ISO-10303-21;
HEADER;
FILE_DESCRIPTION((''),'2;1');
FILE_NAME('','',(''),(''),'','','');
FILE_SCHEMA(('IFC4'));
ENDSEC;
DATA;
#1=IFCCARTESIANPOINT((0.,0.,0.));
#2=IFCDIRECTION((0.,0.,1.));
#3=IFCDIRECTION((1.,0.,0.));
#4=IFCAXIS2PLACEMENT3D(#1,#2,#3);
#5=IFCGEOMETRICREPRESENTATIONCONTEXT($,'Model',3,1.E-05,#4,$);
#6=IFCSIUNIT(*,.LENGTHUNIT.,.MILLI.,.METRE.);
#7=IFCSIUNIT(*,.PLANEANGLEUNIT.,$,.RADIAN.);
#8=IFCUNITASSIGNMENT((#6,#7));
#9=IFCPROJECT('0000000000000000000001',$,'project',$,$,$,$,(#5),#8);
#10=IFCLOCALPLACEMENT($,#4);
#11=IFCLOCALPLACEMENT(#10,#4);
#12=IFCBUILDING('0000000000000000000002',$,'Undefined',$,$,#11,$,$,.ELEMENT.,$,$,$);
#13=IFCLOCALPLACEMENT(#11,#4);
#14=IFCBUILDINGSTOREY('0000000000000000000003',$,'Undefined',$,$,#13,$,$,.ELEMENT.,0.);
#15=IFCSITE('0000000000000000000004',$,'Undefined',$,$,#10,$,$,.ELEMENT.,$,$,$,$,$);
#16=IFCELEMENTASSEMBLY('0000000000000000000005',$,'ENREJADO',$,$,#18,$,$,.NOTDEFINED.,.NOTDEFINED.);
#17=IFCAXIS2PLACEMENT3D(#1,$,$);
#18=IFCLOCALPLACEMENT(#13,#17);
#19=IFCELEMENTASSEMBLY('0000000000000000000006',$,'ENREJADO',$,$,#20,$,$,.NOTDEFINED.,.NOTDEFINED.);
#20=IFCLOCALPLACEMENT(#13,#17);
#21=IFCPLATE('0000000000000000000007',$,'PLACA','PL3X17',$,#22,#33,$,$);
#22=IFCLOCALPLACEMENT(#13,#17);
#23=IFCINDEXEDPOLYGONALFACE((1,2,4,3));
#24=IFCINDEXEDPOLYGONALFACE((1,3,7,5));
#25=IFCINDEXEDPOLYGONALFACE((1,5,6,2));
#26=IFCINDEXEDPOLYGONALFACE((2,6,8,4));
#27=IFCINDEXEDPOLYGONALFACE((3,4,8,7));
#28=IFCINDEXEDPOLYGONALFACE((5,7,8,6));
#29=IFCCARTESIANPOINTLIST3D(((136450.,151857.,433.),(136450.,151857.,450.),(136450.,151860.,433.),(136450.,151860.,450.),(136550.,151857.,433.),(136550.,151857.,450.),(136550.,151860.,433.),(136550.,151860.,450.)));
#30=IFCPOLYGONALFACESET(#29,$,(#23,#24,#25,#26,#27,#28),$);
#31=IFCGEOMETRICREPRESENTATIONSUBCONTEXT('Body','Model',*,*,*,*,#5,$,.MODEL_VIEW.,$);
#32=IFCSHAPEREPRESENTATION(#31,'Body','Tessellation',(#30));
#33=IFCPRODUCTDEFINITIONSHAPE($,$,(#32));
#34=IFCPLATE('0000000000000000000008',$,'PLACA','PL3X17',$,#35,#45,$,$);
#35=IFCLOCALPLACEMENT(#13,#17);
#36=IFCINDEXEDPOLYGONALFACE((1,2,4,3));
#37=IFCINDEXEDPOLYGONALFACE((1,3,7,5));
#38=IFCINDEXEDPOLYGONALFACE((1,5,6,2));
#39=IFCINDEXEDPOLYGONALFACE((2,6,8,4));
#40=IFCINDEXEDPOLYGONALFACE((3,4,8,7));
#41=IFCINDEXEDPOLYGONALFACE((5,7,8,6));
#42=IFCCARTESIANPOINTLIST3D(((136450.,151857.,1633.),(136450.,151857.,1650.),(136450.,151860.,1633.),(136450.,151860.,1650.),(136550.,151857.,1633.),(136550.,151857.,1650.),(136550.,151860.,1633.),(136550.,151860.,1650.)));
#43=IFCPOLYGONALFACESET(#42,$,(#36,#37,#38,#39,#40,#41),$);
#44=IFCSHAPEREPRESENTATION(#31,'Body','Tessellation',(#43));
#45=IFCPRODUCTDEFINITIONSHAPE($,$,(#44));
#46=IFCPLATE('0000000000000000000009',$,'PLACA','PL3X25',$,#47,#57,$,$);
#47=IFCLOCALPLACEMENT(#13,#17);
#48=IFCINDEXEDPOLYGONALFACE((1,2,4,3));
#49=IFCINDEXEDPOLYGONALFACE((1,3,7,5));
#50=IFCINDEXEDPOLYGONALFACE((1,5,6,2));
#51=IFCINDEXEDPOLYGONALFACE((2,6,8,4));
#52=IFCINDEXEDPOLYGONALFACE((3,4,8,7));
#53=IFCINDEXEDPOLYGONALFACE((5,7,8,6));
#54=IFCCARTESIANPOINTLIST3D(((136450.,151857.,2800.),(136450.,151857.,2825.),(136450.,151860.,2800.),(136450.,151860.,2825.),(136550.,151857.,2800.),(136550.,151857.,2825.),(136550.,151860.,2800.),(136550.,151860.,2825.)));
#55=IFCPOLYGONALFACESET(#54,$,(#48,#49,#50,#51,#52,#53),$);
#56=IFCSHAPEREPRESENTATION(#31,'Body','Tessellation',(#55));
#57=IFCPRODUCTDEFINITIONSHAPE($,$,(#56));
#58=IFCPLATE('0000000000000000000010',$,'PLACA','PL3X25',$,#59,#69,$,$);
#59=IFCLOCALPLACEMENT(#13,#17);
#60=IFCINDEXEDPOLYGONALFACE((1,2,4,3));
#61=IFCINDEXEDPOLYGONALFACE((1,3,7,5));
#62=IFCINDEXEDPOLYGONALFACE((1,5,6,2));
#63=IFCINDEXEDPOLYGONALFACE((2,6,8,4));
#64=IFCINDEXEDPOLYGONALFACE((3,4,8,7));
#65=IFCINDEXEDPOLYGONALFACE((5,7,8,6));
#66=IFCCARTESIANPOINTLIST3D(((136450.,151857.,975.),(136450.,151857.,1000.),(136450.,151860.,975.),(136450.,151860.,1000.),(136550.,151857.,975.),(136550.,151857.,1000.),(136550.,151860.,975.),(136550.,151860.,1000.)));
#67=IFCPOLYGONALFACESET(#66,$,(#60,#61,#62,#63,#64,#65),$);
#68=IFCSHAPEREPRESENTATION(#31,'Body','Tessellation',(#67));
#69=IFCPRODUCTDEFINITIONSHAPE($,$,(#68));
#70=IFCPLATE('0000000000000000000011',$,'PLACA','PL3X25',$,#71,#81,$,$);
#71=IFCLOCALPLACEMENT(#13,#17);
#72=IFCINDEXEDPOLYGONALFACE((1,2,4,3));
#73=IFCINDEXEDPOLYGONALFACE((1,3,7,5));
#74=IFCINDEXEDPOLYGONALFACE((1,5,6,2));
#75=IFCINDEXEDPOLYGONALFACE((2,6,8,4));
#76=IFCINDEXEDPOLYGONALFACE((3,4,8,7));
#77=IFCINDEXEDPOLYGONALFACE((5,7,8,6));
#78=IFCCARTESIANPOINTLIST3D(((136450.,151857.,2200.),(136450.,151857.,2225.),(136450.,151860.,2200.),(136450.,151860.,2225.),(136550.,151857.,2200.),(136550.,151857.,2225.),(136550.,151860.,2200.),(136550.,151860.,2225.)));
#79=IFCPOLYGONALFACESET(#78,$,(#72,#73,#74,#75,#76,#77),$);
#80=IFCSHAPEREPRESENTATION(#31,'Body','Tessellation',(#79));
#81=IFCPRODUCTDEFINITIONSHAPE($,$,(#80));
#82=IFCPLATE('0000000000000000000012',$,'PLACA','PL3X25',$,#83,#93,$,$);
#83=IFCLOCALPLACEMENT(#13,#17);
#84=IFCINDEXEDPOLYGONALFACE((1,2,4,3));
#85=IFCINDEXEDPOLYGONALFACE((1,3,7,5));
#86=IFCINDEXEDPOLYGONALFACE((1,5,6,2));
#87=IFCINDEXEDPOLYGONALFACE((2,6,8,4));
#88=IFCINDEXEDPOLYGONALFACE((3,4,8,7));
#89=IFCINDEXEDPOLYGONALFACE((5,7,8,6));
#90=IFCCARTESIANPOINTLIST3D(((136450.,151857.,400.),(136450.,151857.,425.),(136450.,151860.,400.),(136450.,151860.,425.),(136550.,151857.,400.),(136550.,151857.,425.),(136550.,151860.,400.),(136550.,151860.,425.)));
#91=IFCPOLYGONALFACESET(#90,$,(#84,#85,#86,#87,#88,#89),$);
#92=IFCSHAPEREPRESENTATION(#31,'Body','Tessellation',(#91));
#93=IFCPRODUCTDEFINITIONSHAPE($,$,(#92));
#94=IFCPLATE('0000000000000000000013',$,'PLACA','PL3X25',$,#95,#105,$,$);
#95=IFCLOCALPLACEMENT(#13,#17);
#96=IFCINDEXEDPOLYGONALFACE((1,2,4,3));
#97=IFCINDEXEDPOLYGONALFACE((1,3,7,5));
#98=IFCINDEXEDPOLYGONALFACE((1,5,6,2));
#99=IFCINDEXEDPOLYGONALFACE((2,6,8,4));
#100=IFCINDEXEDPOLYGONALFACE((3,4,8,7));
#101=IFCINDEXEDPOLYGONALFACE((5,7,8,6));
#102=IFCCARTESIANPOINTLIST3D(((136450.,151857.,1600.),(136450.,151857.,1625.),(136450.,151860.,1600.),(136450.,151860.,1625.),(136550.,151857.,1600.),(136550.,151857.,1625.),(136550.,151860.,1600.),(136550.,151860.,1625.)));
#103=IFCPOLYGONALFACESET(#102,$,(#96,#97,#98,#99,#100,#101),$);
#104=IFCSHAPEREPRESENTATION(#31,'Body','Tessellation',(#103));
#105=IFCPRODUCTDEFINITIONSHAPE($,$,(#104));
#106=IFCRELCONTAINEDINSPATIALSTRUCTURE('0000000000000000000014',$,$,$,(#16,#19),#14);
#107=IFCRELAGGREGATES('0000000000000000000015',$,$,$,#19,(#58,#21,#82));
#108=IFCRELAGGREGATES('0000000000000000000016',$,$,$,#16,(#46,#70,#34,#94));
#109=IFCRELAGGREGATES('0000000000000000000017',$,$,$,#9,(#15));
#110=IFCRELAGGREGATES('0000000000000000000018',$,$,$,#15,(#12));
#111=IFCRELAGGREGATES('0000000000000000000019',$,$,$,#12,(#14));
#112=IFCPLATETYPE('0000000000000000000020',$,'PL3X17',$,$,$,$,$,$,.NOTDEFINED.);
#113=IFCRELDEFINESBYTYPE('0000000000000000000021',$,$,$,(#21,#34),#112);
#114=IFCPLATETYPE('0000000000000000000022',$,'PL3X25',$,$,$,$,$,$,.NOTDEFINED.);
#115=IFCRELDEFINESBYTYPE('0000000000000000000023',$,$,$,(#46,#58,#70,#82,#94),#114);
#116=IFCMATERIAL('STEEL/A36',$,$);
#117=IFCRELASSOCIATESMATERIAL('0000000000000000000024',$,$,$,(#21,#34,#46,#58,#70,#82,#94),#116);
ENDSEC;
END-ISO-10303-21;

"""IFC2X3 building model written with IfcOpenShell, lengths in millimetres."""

from ifc_helpers import new_model, si_unit, frame, origin_with_axes, place, context, subcontext, project, spatial, polyline, outline, extrude, material, type_object, element, aggregate, save


model = new_model("IFC2X3")

# Units and contexts
model_context = context("Model", 3, precision=1e-05, world=origin_with_axes())
body_context = subcontext(model_context, "Body", "Model", "MODEL_VIEW")
ifc_project = project(units=[si_unit("LENGTHUNIT", "METRE", prefix="MILLI"), si_unit("PLANEANGLEUNIT", "RADIAN")], contexts=[model_context])

# Site, building, storey
site_placement = place(None, origin_with_axes())
site = spatial("IfcSite", under=ifc_project, at=site_placement, Name="Undefined", CompositionType="ELEMENT")
building_placement = place(site_placement, origin_with_axes())
building = spatial("IfcBuilding", under=site, at=building_placement, Name="Undefined", CompositionType="ELEMENT")
storey_placement = place(building_placement, origin_with_axes())
storey = spatial("IfcBuildingStorey", under=building, at=storey_placement, Name="Undefined", CompositionType="ELEMENT", Elevation=0.0)

# Shared definitions
ifc_material_1 = material(Name="STEEL/A36")

# Element assemblies
assembly_1_placement = place(storey_placement, origin_with_axes())
assembly_1 = element("IfcElementAssembly", 1, at=assembly_1_placement, inside=storey, Name="ENREJADO", AssemblyPlace="NOTDEFINED", PredefinedType="NOTDEFINED")
assembly_2_placement = place(storey_placement, origin_with_axes())
assembly_2 = element("IfcElementAssembly", 2, at=assembly_2_placement, inside=storey, Name="ENREJADO", AssemblyPlace="NOTDEFINED", PredefinedType="NOTDEFINED")

# Plates
plate_type_1 = type_object("IfcPlateType", Name="PL3X17", PredefinedType="NOTDEFINED")
plate_1_placement = place(assembly_2_placement, frame((136450.0, 151858.5, 450.0), z_axis=(0.0, -1.0, 0.0), x_axis=(0.0, 0.0, -1.0)))
plate_1 = element("IfcPlate", 3, at=plate_1_placement, type_object=plate_type_1, material=ifc_material_1, Name="PLACA", Description="PL3X17", context=body_context, shape_type="SweptSolid", body=[
    extrude(outline(polyline([(0.0, 0.0), (17.0, 0.0), (17.0, 100.0), (0.0, 100.0), (0.0, 0.0)])), frame((0.0, 0.0, -1.5), z_axis=(0.0, 0.0, 1.0), x_axis=(1.0, 0.0, 0.0)), (0.0, 0.0, 1.0), 3.0),
])
plate_2_placement = place(assembly_1_placement, frame((136450.0, 151858.5, 1650.0), z_axis=(0.0, -1.0, 0.0), x_axis=(0.0, 0.0, -1.0)))
plate_2 = element("IfcPlate", 4, at=plate_2_placement, type_object=plate_type_1, material=ifc_material_1, Name="PLACA", Description="PL3X17", context=body_context, shape_type="SweptSolid", body=[
    extrude(outline(polyline([(0.0, 0.0), (17.0, 0.0), (17.0, 100.0), (0.0, 100.0), (0.0, 0.0)])), frame((0.0, 0.0, -1.5), z_axis=(0.0, 0.0, 1.0), x_axis=(1.0, 0.0, 0.0)), (0.0, 0.0, 1.0), 3.0),
])
plate_type_2 = type_object("IfcPlateType", Name="PL3X25", PredefinedType="NOTDEFINED")
plate_3_placement = place(assembly_1_placement, frame((136450.0, 151858.5, 2825.0), z_axis=(0.0, -1.0, 0.0), x_axis=(0.0, 0.0, -1.0)))
plate_3 = element("IfcPlate", 5, at=plate_3_placement, type_object=plate_type_2, material=ifc_material_1, Name="PLACA", Description="PL3X25", context=body_context, shape_type="SweptSolid", body=[
    extrude(outline(polyline([(0.0, 0.0), (25.0, 0.0), (25.0, 100.0), (0.0, 100.0), (0.0, 0.0)])), frame((0.0, 0.0, -1.5), z_axis=(0.0, 0.0, 1.0), x_axis=(1.0, 0.0, 0.0)), (0.0, 0.0, 1.0), 3.0),
])
plate_4_placement = place(assembly_2_placement, frame((136450.0, 151858.5, 1000.0), z_axis=(0.0, -1.0, 0.0), x_axis=(0.0, 0.0, -1.0)))
plate_4 = element("IfcPlate", 6, at=plate_4_placement, type_object=plate_type_2, material=ifc_material_1, Name="PLACA", Description="PL3X25", context=body_context, shape_type="SweptSolid", body=[
    extrude(outline(polyline([(0.0, 0.0), (25.0, 0.0), (25.0, 100.0), (0.0, 100.0), (0.0, 0.0)])), frame((0.0, 0.0, -1.5), z_axis=(0.0, 0.0, 1.0), x_axis=(1.0, 0.0, 0.0)), (0.0, 0.0, 1.0), 3.0),
])
plate_5_placement = place(assembly_1_placement, frame((136450.0, 151858.5, 2225.0), z_axis=(0.0, -1.0, 0.0), x_axis=(0.0, 0.0, -1.0)))
plate_5 = element("IfcPlate", 7, at=plate_5_placement, type_object=plate_type_2, material=ifc_material_1, Name="PLACA", Description="PL3X25", context=body_context, shape_type="SweptSolid", body=[
    extrude(outline(polyline([(0.0, 0.0), (25.0, 0.0), (25.0, 100.0), (0.0, 100.0), (0.0, 0.0)])), frame((0.0, 0.0, -1.5), z_axis=(0.0, 0.0, 1.0), x_axis=(1.0, 0.0, 0.0)), (0.0, 0.0, 1.0), 3.0),
])
plate_6_placement = place(assembly_2_placement, frame((136450.0, 151858.5, 425.0), z_axis=(0.0, -1.0, 0.0), x_axis=(0.0, 0.0, -1.0)))
plate_6 = element("IfcPlate", 8, at=plate_6_placement, type_object=plate_type_2, material=ifc_material_1, Name="PLACA", Description="PL3X25", context=body_context, shape_type="SweptSolid", body=[
    extrude(outline(polyline([(0.0, 0.0), (25.0, 0.0), (25.0, 100.0), (0.0, 100.0), (0.0, 0.0)])), frame((0.0, 0.0, -1.5), z_axis=(0.0, 0.0, 1.0), x_axis=(1.0, 0.0, 0.0)), (0.0, 0.0, 1.0), 3.0),
])
aggregate(assembly_2, [plate_4, plate_1, plate_6])
plate_7_placement = place(assembly_1_placement, frame((136450.0, 151858.5, 1625.0), z_axis=(0.0, -1.0, 0.0), x_axis=(0.0, 0.0, -1.0)))
plate_7 = element("IfcPlate", 9, at=plate_7_placement, type_object=plate_type_2, material=ifc_material_1, Name="PLACA", Description="PL3X25", context=body_context, shape_type="SweptSolid", body=[
    extrude(outline(polyline([(0.0, 0.0), (25.0, 0.0), (25.0, 100.0), (0.0, 100.0), (0.0, 0.0)])), frame((0.0, 0.0, -1.5), z_axis=(0.0, 0.0, 1.0), x_axis=(1.0, 0.0, 0.0)), (0.0, 0.0, 1.0), 3.0),
])
aggregate(assembly_1, [plate_3, plate_5, plate_2, plate_7])

save(model, "model.ifc")
